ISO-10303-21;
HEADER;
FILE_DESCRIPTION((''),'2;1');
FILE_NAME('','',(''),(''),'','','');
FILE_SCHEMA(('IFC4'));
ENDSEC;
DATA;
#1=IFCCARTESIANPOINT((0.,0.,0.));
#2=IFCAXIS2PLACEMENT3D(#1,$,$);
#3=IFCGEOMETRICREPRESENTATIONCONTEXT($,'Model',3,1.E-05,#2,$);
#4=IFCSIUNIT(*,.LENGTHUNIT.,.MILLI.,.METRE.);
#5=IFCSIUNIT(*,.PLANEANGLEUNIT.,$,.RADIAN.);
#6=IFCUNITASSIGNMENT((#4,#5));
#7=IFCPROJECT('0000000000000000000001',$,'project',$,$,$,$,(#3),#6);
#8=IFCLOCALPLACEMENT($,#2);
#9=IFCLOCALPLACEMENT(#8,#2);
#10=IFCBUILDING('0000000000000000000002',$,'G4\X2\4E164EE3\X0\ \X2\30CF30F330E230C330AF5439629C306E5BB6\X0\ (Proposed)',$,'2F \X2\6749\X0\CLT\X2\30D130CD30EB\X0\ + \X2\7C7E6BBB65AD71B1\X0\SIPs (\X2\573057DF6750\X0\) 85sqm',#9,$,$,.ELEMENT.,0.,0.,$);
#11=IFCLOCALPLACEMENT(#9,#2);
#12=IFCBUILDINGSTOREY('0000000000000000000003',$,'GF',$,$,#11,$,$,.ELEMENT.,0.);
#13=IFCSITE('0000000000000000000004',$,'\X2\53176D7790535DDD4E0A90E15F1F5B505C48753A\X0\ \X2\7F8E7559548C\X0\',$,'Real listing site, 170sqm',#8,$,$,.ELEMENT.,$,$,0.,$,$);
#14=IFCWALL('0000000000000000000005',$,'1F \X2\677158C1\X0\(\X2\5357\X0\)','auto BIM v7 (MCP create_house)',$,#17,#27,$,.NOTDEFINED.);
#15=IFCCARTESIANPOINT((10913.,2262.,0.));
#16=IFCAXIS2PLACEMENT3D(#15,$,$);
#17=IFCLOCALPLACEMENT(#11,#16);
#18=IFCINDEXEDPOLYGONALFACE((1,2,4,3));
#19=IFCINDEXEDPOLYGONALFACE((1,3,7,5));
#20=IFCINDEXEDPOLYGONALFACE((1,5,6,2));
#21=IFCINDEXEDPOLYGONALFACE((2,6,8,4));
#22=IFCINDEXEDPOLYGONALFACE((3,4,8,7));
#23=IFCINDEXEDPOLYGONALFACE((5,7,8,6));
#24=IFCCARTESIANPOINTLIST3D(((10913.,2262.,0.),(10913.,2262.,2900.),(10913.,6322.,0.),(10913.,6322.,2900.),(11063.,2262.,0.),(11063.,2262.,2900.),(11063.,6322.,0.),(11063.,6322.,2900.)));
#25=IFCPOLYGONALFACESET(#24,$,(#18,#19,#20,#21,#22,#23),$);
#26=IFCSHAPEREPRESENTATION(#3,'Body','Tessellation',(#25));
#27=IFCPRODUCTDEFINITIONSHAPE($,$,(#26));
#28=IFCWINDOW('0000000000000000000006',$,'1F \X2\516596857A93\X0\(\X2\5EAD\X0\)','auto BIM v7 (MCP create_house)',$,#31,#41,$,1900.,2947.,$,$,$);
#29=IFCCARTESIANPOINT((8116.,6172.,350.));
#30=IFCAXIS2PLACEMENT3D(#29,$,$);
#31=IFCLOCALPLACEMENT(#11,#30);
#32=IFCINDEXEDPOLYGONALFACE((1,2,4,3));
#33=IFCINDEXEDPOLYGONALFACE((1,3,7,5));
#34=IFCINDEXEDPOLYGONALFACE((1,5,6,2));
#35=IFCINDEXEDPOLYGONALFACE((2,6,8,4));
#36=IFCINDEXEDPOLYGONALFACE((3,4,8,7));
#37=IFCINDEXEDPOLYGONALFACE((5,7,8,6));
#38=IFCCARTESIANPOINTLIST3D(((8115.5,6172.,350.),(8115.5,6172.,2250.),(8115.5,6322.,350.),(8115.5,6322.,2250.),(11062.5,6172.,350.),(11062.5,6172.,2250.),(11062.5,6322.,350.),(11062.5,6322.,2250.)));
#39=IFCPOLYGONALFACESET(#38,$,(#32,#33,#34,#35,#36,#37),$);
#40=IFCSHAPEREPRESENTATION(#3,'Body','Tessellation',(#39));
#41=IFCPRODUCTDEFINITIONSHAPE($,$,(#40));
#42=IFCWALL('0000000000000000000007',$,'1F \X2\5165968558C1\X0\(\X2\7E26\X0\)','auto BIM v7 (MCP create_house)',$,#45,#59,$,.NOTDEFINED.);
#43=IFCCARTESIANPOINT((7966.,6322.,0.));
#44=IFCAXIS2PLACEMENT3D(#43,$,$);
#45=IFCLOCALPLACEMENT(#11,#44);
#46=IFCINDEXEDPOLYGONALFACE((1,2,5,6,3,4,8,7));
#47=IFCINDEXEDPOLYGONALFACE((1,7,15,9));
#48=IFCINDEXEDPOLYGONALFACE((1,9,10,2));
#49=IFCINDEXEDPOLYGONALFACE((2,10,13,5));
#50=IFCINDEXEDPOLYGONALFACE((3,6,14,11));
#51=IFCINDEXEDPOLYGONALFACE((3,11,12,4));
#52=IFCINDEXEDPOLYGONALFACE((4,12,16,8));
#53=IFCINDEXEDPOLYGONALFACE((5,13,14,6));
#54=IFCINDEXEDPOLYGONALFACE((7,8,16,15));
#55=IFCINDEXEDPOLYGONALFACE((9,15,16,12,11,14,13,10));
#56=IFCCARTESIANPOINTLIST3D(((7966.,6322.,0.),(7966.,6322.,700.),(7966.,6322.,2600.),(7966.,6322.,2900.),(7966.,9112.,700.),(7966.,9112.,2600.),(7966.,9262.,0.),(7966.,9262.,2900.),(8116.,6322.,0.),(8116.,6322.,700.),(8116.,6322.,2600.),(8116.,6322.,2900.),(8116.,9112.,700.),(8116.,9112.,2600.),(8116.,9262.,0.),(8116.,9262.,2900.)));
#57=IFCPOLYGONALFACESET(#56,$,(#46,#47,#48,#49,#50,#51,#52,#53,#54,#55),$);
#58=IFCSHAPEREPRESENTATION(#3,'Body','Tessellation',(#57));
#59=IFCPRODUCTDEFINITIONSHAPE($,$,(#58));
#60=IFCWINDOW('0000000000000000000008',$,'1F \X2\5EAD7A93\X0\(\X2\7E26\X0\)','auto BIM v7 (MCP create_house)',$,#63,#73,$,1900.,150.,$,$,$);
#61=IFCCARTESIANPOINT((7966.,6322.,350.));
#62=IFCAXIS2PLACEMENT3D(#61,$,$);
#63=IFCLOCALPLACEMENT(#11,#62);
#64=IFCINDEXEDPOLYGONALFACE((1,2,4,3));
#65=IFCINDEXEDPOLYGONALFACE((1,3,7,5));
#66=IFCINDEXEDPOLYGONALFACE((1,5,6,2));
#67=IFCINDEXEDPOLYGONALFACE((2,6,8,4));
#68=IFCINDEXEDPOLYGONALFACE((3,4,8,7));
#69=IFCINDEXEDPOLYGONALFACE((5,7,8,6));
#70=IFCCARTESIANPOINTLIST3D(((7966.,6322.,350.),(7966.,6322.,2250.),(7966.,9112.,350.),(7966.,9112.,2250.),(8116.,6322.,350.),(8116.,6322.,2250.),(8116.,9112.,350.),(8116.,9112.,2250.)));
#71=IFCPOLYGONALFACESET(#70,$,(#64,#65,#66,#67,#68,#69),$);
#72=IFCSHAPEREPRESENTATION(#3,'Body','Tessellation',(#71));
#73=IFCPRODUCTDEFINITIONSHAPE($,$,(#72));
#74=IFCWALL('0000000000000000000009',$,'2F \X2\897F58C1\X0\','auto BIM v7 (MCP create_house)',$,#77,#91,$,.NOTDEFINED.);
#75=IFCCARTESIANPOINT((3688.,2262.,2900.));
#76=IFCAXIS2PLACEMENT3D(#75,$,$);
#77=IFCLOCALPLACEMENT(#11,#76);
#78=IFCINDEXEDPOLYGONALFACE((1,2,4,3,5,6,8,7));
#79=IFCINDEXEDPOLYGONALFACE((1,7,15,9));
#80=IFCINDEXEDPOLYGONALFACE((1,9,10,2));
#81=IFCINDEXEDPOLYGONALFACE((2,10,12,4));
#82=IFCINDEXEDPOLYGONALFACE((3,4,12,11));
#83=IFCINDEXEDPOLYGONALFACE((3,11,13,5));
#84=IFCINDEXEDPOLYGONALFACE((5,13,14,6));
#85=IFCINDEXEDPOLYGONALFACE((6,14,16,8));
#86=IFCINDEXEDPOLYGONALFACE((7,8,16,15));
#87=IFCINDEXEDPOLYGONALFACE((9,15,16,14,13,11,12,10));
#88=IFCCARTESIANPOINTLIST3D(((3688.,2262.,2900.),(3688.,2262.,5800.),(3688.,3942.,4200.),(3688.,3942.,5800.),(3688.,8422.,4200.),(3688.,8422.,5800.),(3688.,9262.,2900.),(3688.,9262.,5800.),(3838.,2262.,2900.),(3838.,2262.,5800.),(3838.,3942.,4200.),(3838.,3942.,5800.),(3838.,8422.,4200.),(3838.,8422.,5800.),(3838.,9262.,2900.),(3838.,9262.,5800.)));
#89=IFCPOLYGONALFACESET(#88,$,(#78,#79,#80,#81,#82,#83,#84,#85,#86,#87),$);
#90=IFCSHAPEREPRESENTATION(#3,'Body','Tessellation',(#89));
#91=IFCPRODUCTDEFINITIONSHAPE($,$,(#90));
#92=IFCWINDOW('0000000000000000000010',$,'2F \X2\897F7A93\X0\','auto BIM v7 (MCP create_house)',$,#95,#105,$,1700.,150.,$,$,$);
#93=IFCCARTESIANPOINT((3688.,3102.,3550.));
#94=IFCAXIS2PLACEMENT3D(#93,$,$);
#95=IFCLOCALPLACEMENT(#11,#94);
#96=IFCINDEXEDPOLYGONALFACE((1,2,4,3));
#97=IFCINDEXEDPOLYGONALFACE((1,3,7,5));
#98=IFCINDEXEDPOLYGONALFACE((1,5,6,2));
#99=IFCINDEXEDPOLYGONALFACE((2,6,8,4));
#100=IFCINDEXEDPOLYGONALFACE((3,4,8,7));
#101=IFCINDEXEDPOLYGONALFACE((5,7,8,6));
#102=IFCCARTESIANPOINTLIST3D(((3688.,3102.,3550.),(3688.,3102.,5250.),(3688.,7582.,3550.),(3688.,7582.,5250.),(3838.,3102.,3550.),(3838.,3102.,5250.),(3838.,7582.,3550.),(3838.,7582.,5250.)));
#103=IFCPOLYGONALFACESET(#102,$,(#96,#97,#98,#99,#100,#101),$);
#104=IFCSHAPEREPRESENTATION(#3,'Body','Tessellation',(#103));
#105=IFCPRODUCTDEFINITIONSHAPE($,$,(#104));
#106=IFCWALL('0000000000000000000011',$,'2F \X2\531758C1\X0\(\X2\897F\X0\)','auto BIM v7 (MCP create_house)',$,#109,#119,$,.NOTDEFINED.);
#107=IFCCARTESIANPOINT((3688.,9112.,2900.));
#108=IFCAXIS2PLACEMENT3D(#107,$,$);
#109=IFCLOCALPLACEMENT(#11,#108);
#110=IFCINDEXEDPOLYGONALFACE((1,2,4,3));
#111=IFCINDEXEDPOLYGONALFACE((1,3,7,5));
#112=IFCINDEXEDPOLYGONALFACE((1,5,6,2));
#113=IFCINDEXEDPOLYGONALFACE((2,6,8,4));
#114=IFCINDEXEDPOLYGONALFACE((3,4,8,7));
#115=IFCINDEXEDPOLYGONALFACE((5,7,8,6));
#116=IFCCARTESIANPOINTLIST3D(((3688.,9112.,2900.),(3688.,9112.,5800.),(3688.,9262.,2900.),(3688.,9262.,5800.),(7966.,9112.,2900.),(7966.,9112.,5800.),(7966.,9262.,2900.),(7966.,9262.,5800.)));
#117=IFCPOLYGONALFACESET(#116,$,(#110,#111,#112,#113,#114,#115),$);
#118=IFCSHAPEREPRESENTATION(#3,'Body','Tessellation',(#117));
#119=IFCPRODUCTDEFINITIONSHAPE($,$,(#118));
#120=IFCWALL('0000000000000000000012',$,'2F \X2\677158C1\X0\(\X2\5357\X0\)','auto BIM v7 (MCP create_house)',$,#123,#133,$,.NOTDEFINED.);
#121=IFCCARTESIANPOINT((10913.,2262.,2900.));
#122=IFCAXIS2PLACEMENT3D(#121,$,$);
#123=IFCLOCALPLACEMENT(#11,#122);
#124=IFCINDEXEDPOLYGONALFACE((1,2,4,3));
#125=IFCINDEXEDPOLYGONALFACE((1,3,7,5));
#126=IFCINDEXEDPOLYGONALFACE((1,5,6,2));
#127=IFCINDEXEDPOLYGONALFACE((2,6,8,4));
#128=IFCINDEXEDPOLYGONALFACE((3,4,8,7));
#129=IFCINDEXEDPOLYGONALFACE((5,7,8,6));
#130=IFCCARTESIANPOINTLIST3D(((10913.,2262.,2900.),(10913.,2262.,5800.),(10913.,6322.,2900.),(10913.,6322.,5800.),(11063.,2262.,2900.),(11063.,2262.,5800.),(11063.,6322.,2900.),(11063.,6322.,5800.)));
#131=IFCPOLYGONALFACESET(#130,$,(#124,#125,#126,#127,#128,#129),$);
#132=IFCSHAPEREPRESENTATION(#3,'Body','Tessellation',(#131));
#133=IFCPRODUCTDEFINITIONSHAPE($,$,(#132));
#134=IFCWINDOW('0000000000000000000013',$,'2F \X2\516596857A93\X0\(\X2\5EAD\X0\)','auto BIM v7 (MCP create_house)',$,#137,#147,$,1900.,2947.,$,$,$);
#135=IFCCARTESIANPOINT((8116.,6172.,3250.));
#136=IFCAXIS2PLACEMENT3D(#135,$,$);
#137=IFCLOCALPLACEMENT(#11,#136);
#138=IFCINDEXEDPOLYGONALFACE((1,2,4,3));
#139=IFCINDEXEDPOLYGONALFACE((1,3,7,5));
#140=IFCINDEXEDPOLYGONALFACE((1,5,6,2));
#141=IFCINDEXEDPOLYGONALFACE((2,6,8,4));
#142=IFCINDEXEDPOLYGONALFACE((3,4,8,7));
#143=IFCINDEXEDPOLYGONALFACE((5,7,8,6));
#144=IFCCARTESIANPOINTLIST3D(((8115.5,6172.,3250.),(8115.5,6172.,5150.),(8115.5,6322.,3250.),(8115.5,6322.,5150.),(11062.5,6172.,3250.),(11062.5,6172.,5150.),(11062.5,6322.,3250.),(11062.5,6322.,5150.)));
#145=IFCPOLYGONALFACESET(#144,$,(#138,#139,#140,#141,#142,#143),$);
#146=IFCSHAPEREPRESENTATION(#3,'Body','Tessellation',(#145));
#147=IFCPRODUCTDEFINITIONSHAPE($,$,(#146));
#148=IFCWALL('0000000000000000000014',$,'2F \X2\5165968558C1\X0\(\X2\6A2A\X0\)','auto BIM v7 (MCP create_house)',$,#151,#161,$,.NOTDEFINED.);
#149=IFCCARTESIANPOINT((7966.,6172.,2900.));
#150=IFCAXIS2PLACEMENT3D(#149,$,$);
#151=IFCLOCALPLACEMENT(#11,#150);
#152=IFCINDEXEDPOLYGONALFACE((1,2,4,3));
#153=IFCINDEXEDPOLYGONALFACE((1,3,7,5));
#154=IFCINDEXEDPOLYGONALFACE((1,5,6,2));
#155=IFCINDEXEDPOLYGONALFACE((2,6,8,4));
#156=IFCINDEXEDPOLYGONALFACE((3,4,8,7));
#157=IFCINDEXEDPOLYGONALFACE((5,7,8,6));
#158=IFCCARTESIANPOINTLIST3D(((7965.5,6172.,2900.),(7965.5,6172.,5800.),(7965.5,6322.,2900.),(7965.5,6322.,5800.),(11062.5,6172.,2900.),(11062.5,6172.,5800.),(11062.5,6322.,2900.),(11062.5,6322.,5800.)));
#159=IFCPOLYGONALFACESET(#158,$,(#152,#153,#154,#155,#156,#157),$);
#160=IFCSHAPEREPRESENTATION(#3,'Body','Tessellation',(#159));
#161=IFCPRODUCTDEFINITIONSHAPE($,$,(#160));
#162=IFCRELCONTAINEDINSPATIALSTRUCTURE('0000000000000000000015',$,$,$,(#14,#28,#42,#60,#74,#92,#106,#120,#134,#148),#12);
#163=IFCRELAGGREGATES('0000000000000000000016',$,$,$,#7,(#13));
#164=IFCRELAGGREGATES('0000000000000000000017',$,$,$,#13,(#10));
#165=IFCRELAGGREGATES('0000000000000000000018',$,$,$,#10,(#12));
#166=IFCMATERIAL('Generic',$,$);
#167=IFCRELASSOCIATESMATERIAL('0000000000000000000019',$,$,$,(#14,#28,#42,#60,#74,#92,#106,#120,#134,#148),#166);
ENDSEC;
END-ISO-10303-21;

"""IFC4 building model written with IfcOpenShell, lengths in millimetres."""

from ifc_helpers import new_model, si_unit, frame, frame_2d, origin, place, context, project, spatial, rectangle, extrude, material, element, fill, save


model = new_model("IFC4")

# Units and contexts
model_context = context("Model", 3, precision=1e-05, world=origin())
ifc_project = project(units=[si_unit("LENGTHUNIT", "METRE", prefix="MILLI"), si_unit("PLANEANGLEUNIT", "RADIAN")], contexts=[model_context])

# Site, building, storey
site_placement = place(None, origin())
site = spatial("IfcSite", under=ifc_project, at=site_placement, Name="北海道川上郡弟子屈町 美留和", ObjectType="Real listing site, 170sqm", CompositionType="ELEMENT", RefElevation=0.0)
building_placement = place(site_placement, origin())
building = spatial("IfcBuilding", under=site, at=building_placement, Name="G4世代 ハンモック吹抜の家 (Proposed)", ObjectType="2F 杉CLTパネル + 籾殻断熱SIPs (地域材) 85sqm", CompositionType="ELEMENT", ElevationOfRefHeight=0.0, ElevationOfTerrain=0.0)
storey_placement = place(building_placement, origin())
storey = spatial("IfcBuildingStorey", under=building, at=storey_placement, Name="GF", CompositionType="ELEMENT", Elevation=0.0)

# Shared definitions
ifc_material = material(Name="Generic")

# Wall, opening, window
wall_1_placement = place(storey_placement, frame((10913.0, 2262.0, 0.0)))
wall_1 = element("IfcWall", 1, at=wall_1_placement, inside=storey, material=ifc_material, Name="1F 東壁(南)", Description="auto BIM v7 (MCP create_house)", PredefinedType="NOTDEFINED", context=model_context, shape_type="SweptSolid", body=[
    extrude(rectangle(XDim=150.0, YDim=4060.0, at=frame_2d((75.0, 2030.0))), frame((10913.0, 2262.0, 0.0)), (0.0, 0.0, 1.0), 2900.0),
])
opening_1_placement = place(storey_placement, frame((8116.0, 6172.0, 350.0)))
opening_1 = element("IfcOpeningElement", 2, at=opening_1_placement, cuts=wall_1, PredefinedType="NOTDEFINED", context=model_context, shape_type="SweptSolid", body=[
    extrude(rectangle(XDim=2947.0, YDim=150.0, at=frame_2d((1473.0, 75.0))), frame((8116.0, 6172.0, 350.0)), (0.0, 0.0, 1.0), 1900.0),
])
window_1_placement = place(storey_placement, frame((8116.0, 6172.0, 350.0)))
window_1 = element("IfcWindow", 3, at=window_1_placement, inside=storey, material=ifc_material, Name="1F 入隅窓(庭)", Description="auto BIM v7 (MCP create_house)", OverallHeight=1900.0, OverallWidth=2947.0, context=model_context, shape_type="SweptSolid", body=[
    extrude(rectangle(XDim=2947.0, YDim=150.0, at=frame_2d((1473.0, 75.0))), frame((8116.0, 6172.0, 350.0)), (0.0, 0.0, 1.0), 1900.0),
])
fill(opening_1, window_1)

# Wall, opening, window
wall_2_placement = place(storey_placement, frame((7966.0, 6322.0, 0.0)))
wall_2 = element("IfcWall", 4, at=wall_2_placement, inside=storey, material=ifc_material, Name="1F 入隅壁(縦)", Description="auto BIM v7 (MCP create_house)", PredefinedType="NOTDEFINED", context=model_context, shape_type="SweptSolid", body=[
    extrude(rectangle(XDim=150.0, YDim=2940.0, at=frame_2d((75.0, 1470.0))), frame((7966.0, 6322.0, 0.0)), (0.0, 0.0, 1.0), 2900.0),
])
opening_2_placement = place(storey_placement, frame((7966.0, 6322.0, 350.0)))
opening_2 = element("IfcOpeningElement", 5, at=opening_2_placement, cuts=wall_2, PredefinedType="NOTDEFINED", context=model_context, shape_type="SweptSolid", body=[
    extrude(rectangle(XDim=150.0, YDim=2790.0, at=frame_2d((75.0, 1395.0))), frame((7966.0, 6322.0, 350.0)), (0.0, 0.0, 1.0), 1900.0),
])
window_2_placement = place(storey_placement, frame((7966.0, 6322.0, 350.0)))
window_2 = element("IfcWindow", 6, at=window_2_placement, inside=storey, material=ifc_material, Name="1F 庭窓(縦)", Description="auto BIM v7 (MCP create_house)", OverallHeight=1900.0, OverallWidth=150.0, context=model_context, shape_type="SweptSolid", body=[
    extrude(rectangle(XDim=150.0, YDim=2790.0, at=frame_2d((75.0, 1395.0))), frame((7966.0, 6322.0, 350.0)), (0.0, 0.0, 1.0), 1900.0),
])
fill(opening_2, window_2)

# Wall, opening, window
wall_3_placement = place(storey_placement, frame((3688.0, 2262.0, 2900.0)))
wall_3 = element("IfcWall", 7, at=wall_3_placement, inside=storey, material=ifc_material, Name="2F 西壁", Description="auto BIM v7 (MCP create_house)", PredefinedType="NOTDEFINED", context=model_context, shape_type="SweptSolid", body=[
    extrude(rectangle(XDim=150.0, YDim=7000.0, at=frame_2d((75.0, 3500.0))), frame((3688.0, 2262.0, 2900.0)), (0.0, 0.0, 1.0), 2900.0),
])
opening_3_placement = place(storey_placement, frame((3688.0, 3102.0, 3550.0)))
opening_3 = element("IfcOpeningElement", 8, at=opening_3_placement, cuts=wall_3, PredefinedType="NOTDEFINED", context=model_context, shape_type="SweptSolid", body=[
    extrude(rectangle(XDim=150.0, YDim=4480.0, at=frame_2d((75.0, 2240.0))), frame((3688.0, 3102.0, 3550.0)), (0.0, 0.0, 1.0), 1700.0),
])
window_3_placement = place(storey_placement, frame((3688.0, 3102.0, 3550.0)))
window_3 = element("IfcWindow", 9, at=window_3_placement, inside=storey, material=ifc_material, Name="2F 西窓", Description="auto BIM v7 (MCP create_house)", OverallHeight=1700.0, OverallWidth=150.0, context=model_context, shape_type="SweptSolid", body=[
    extrude(rectangle(XDim=150.0, YDim=4480.0, at=frame_2d((75.0, 2240.0))), frame((3688.0, 3102.0, 3550.0)), (0.0, 0.0, 1.0), 1700.0),
])
fill(opening_3, window_3)

# Wall
wall_4_placement = place(storey_placement, frame((3688.0, 9112.0, 2900.0)))
element("IfcWall", 10, at=wall_4_placement, inside=storey, material=ifc_material, Name="2F 北壁(西)", Description="auto BIM v7 (MCP create_house)", PredefinedType="NOTDEFINED", context=model_context, shape_type="SweptSolid", body=[
    extrude(rectangle(XDim=4278.0, YDim=150.0, at=frame_2d((2139.0, 75.0))), frame((3688.0, 9112.0, 2900.0)), (0.0, 0.0, 1.0), 2900.0),
])

# Wall, opening, window
wall_5_placement = place(storey_placement, frame((10913.0, 2262.0, 2900.0)))
wall_5 = element("IfcWall", 11, at=wall_5_placement, inside=storey, material=ifc_material, Name="2F 東壁(南)", Description="auto BIM v7 (MCP create_house)", PredefinedType="NOTDEFINED", context=model_context, shape_type="SweptSolid", body=[
    extrude(rectangle(XDim=150.0, YDim=4060.0, at=frame_2d((75.0, 2030.0))), frame((10913.0, 2262.0, 2900.0)), (0.0, 0.0, 1.0), 2900.0),
])
opening_4_placement = place(storey_placement, frame((8116.0, 6172.0, 3250.0)))
opening_4 = element("IfcOpeningElement", 12, at=opening_4_placement, cuts=wall_5, PredefinedType="NOTDEFINED", context=model_context, shape_type="SweptSolid", body=[
    extrude(rectangle(XDim=2947.0, YDim=150.0, at=frame_2d((1473.0, 75.0))), frame((8116.0, 6172.0, 3250.0)), (0.0, 0.0, 1.0), 1900.0),
])
window_4_placement = place(storey_placement, frame((8116.0, 6172.0, 3250.0)))
window_4 = element("IfcWindow", 13, at=window_4_placement, inside=storey, material=ifc_material, Name="2F 入隅窓(庭)", Description="auto BIM v7 (MCP create_house)", OverallHeight=1900.0, OverallWidth=2947.0, context=model_context, shape_type="SweptSolid", body=[
    extrude(rectangle(XDim=2947.0, YDim=150.0, at=frame_2d((1473.0, 75.0))), frame((8116.0, 6172.0, 3250.0)), (0.0, 0.0, 1.0), 1900.0),
])
fill(opening_4, window_4)

# Wall
wall_6_placement = place(storey_placement, frame((7966.0, 6172.0, 2900.0)))
element("IfcWall", 14, at=wall_6_placement, inside=storey, material=ifc_material, Name="2F 入隅壁(横)", Description="auto BIM v7 (MCP create_house)", PredefinedType="NOTDEFINED", context=model_context, shape_type="SweptSolid", body=[
    extrude(rectangle(XDim=3097.0, YDim=150.0, at=frame_2d((1548.0, 75.0))), frame((7966.0, 6172.0, 2900.0)), (0.0, 0.0, 1.0), 2900.0),
])

save(model, "model.ifc")
